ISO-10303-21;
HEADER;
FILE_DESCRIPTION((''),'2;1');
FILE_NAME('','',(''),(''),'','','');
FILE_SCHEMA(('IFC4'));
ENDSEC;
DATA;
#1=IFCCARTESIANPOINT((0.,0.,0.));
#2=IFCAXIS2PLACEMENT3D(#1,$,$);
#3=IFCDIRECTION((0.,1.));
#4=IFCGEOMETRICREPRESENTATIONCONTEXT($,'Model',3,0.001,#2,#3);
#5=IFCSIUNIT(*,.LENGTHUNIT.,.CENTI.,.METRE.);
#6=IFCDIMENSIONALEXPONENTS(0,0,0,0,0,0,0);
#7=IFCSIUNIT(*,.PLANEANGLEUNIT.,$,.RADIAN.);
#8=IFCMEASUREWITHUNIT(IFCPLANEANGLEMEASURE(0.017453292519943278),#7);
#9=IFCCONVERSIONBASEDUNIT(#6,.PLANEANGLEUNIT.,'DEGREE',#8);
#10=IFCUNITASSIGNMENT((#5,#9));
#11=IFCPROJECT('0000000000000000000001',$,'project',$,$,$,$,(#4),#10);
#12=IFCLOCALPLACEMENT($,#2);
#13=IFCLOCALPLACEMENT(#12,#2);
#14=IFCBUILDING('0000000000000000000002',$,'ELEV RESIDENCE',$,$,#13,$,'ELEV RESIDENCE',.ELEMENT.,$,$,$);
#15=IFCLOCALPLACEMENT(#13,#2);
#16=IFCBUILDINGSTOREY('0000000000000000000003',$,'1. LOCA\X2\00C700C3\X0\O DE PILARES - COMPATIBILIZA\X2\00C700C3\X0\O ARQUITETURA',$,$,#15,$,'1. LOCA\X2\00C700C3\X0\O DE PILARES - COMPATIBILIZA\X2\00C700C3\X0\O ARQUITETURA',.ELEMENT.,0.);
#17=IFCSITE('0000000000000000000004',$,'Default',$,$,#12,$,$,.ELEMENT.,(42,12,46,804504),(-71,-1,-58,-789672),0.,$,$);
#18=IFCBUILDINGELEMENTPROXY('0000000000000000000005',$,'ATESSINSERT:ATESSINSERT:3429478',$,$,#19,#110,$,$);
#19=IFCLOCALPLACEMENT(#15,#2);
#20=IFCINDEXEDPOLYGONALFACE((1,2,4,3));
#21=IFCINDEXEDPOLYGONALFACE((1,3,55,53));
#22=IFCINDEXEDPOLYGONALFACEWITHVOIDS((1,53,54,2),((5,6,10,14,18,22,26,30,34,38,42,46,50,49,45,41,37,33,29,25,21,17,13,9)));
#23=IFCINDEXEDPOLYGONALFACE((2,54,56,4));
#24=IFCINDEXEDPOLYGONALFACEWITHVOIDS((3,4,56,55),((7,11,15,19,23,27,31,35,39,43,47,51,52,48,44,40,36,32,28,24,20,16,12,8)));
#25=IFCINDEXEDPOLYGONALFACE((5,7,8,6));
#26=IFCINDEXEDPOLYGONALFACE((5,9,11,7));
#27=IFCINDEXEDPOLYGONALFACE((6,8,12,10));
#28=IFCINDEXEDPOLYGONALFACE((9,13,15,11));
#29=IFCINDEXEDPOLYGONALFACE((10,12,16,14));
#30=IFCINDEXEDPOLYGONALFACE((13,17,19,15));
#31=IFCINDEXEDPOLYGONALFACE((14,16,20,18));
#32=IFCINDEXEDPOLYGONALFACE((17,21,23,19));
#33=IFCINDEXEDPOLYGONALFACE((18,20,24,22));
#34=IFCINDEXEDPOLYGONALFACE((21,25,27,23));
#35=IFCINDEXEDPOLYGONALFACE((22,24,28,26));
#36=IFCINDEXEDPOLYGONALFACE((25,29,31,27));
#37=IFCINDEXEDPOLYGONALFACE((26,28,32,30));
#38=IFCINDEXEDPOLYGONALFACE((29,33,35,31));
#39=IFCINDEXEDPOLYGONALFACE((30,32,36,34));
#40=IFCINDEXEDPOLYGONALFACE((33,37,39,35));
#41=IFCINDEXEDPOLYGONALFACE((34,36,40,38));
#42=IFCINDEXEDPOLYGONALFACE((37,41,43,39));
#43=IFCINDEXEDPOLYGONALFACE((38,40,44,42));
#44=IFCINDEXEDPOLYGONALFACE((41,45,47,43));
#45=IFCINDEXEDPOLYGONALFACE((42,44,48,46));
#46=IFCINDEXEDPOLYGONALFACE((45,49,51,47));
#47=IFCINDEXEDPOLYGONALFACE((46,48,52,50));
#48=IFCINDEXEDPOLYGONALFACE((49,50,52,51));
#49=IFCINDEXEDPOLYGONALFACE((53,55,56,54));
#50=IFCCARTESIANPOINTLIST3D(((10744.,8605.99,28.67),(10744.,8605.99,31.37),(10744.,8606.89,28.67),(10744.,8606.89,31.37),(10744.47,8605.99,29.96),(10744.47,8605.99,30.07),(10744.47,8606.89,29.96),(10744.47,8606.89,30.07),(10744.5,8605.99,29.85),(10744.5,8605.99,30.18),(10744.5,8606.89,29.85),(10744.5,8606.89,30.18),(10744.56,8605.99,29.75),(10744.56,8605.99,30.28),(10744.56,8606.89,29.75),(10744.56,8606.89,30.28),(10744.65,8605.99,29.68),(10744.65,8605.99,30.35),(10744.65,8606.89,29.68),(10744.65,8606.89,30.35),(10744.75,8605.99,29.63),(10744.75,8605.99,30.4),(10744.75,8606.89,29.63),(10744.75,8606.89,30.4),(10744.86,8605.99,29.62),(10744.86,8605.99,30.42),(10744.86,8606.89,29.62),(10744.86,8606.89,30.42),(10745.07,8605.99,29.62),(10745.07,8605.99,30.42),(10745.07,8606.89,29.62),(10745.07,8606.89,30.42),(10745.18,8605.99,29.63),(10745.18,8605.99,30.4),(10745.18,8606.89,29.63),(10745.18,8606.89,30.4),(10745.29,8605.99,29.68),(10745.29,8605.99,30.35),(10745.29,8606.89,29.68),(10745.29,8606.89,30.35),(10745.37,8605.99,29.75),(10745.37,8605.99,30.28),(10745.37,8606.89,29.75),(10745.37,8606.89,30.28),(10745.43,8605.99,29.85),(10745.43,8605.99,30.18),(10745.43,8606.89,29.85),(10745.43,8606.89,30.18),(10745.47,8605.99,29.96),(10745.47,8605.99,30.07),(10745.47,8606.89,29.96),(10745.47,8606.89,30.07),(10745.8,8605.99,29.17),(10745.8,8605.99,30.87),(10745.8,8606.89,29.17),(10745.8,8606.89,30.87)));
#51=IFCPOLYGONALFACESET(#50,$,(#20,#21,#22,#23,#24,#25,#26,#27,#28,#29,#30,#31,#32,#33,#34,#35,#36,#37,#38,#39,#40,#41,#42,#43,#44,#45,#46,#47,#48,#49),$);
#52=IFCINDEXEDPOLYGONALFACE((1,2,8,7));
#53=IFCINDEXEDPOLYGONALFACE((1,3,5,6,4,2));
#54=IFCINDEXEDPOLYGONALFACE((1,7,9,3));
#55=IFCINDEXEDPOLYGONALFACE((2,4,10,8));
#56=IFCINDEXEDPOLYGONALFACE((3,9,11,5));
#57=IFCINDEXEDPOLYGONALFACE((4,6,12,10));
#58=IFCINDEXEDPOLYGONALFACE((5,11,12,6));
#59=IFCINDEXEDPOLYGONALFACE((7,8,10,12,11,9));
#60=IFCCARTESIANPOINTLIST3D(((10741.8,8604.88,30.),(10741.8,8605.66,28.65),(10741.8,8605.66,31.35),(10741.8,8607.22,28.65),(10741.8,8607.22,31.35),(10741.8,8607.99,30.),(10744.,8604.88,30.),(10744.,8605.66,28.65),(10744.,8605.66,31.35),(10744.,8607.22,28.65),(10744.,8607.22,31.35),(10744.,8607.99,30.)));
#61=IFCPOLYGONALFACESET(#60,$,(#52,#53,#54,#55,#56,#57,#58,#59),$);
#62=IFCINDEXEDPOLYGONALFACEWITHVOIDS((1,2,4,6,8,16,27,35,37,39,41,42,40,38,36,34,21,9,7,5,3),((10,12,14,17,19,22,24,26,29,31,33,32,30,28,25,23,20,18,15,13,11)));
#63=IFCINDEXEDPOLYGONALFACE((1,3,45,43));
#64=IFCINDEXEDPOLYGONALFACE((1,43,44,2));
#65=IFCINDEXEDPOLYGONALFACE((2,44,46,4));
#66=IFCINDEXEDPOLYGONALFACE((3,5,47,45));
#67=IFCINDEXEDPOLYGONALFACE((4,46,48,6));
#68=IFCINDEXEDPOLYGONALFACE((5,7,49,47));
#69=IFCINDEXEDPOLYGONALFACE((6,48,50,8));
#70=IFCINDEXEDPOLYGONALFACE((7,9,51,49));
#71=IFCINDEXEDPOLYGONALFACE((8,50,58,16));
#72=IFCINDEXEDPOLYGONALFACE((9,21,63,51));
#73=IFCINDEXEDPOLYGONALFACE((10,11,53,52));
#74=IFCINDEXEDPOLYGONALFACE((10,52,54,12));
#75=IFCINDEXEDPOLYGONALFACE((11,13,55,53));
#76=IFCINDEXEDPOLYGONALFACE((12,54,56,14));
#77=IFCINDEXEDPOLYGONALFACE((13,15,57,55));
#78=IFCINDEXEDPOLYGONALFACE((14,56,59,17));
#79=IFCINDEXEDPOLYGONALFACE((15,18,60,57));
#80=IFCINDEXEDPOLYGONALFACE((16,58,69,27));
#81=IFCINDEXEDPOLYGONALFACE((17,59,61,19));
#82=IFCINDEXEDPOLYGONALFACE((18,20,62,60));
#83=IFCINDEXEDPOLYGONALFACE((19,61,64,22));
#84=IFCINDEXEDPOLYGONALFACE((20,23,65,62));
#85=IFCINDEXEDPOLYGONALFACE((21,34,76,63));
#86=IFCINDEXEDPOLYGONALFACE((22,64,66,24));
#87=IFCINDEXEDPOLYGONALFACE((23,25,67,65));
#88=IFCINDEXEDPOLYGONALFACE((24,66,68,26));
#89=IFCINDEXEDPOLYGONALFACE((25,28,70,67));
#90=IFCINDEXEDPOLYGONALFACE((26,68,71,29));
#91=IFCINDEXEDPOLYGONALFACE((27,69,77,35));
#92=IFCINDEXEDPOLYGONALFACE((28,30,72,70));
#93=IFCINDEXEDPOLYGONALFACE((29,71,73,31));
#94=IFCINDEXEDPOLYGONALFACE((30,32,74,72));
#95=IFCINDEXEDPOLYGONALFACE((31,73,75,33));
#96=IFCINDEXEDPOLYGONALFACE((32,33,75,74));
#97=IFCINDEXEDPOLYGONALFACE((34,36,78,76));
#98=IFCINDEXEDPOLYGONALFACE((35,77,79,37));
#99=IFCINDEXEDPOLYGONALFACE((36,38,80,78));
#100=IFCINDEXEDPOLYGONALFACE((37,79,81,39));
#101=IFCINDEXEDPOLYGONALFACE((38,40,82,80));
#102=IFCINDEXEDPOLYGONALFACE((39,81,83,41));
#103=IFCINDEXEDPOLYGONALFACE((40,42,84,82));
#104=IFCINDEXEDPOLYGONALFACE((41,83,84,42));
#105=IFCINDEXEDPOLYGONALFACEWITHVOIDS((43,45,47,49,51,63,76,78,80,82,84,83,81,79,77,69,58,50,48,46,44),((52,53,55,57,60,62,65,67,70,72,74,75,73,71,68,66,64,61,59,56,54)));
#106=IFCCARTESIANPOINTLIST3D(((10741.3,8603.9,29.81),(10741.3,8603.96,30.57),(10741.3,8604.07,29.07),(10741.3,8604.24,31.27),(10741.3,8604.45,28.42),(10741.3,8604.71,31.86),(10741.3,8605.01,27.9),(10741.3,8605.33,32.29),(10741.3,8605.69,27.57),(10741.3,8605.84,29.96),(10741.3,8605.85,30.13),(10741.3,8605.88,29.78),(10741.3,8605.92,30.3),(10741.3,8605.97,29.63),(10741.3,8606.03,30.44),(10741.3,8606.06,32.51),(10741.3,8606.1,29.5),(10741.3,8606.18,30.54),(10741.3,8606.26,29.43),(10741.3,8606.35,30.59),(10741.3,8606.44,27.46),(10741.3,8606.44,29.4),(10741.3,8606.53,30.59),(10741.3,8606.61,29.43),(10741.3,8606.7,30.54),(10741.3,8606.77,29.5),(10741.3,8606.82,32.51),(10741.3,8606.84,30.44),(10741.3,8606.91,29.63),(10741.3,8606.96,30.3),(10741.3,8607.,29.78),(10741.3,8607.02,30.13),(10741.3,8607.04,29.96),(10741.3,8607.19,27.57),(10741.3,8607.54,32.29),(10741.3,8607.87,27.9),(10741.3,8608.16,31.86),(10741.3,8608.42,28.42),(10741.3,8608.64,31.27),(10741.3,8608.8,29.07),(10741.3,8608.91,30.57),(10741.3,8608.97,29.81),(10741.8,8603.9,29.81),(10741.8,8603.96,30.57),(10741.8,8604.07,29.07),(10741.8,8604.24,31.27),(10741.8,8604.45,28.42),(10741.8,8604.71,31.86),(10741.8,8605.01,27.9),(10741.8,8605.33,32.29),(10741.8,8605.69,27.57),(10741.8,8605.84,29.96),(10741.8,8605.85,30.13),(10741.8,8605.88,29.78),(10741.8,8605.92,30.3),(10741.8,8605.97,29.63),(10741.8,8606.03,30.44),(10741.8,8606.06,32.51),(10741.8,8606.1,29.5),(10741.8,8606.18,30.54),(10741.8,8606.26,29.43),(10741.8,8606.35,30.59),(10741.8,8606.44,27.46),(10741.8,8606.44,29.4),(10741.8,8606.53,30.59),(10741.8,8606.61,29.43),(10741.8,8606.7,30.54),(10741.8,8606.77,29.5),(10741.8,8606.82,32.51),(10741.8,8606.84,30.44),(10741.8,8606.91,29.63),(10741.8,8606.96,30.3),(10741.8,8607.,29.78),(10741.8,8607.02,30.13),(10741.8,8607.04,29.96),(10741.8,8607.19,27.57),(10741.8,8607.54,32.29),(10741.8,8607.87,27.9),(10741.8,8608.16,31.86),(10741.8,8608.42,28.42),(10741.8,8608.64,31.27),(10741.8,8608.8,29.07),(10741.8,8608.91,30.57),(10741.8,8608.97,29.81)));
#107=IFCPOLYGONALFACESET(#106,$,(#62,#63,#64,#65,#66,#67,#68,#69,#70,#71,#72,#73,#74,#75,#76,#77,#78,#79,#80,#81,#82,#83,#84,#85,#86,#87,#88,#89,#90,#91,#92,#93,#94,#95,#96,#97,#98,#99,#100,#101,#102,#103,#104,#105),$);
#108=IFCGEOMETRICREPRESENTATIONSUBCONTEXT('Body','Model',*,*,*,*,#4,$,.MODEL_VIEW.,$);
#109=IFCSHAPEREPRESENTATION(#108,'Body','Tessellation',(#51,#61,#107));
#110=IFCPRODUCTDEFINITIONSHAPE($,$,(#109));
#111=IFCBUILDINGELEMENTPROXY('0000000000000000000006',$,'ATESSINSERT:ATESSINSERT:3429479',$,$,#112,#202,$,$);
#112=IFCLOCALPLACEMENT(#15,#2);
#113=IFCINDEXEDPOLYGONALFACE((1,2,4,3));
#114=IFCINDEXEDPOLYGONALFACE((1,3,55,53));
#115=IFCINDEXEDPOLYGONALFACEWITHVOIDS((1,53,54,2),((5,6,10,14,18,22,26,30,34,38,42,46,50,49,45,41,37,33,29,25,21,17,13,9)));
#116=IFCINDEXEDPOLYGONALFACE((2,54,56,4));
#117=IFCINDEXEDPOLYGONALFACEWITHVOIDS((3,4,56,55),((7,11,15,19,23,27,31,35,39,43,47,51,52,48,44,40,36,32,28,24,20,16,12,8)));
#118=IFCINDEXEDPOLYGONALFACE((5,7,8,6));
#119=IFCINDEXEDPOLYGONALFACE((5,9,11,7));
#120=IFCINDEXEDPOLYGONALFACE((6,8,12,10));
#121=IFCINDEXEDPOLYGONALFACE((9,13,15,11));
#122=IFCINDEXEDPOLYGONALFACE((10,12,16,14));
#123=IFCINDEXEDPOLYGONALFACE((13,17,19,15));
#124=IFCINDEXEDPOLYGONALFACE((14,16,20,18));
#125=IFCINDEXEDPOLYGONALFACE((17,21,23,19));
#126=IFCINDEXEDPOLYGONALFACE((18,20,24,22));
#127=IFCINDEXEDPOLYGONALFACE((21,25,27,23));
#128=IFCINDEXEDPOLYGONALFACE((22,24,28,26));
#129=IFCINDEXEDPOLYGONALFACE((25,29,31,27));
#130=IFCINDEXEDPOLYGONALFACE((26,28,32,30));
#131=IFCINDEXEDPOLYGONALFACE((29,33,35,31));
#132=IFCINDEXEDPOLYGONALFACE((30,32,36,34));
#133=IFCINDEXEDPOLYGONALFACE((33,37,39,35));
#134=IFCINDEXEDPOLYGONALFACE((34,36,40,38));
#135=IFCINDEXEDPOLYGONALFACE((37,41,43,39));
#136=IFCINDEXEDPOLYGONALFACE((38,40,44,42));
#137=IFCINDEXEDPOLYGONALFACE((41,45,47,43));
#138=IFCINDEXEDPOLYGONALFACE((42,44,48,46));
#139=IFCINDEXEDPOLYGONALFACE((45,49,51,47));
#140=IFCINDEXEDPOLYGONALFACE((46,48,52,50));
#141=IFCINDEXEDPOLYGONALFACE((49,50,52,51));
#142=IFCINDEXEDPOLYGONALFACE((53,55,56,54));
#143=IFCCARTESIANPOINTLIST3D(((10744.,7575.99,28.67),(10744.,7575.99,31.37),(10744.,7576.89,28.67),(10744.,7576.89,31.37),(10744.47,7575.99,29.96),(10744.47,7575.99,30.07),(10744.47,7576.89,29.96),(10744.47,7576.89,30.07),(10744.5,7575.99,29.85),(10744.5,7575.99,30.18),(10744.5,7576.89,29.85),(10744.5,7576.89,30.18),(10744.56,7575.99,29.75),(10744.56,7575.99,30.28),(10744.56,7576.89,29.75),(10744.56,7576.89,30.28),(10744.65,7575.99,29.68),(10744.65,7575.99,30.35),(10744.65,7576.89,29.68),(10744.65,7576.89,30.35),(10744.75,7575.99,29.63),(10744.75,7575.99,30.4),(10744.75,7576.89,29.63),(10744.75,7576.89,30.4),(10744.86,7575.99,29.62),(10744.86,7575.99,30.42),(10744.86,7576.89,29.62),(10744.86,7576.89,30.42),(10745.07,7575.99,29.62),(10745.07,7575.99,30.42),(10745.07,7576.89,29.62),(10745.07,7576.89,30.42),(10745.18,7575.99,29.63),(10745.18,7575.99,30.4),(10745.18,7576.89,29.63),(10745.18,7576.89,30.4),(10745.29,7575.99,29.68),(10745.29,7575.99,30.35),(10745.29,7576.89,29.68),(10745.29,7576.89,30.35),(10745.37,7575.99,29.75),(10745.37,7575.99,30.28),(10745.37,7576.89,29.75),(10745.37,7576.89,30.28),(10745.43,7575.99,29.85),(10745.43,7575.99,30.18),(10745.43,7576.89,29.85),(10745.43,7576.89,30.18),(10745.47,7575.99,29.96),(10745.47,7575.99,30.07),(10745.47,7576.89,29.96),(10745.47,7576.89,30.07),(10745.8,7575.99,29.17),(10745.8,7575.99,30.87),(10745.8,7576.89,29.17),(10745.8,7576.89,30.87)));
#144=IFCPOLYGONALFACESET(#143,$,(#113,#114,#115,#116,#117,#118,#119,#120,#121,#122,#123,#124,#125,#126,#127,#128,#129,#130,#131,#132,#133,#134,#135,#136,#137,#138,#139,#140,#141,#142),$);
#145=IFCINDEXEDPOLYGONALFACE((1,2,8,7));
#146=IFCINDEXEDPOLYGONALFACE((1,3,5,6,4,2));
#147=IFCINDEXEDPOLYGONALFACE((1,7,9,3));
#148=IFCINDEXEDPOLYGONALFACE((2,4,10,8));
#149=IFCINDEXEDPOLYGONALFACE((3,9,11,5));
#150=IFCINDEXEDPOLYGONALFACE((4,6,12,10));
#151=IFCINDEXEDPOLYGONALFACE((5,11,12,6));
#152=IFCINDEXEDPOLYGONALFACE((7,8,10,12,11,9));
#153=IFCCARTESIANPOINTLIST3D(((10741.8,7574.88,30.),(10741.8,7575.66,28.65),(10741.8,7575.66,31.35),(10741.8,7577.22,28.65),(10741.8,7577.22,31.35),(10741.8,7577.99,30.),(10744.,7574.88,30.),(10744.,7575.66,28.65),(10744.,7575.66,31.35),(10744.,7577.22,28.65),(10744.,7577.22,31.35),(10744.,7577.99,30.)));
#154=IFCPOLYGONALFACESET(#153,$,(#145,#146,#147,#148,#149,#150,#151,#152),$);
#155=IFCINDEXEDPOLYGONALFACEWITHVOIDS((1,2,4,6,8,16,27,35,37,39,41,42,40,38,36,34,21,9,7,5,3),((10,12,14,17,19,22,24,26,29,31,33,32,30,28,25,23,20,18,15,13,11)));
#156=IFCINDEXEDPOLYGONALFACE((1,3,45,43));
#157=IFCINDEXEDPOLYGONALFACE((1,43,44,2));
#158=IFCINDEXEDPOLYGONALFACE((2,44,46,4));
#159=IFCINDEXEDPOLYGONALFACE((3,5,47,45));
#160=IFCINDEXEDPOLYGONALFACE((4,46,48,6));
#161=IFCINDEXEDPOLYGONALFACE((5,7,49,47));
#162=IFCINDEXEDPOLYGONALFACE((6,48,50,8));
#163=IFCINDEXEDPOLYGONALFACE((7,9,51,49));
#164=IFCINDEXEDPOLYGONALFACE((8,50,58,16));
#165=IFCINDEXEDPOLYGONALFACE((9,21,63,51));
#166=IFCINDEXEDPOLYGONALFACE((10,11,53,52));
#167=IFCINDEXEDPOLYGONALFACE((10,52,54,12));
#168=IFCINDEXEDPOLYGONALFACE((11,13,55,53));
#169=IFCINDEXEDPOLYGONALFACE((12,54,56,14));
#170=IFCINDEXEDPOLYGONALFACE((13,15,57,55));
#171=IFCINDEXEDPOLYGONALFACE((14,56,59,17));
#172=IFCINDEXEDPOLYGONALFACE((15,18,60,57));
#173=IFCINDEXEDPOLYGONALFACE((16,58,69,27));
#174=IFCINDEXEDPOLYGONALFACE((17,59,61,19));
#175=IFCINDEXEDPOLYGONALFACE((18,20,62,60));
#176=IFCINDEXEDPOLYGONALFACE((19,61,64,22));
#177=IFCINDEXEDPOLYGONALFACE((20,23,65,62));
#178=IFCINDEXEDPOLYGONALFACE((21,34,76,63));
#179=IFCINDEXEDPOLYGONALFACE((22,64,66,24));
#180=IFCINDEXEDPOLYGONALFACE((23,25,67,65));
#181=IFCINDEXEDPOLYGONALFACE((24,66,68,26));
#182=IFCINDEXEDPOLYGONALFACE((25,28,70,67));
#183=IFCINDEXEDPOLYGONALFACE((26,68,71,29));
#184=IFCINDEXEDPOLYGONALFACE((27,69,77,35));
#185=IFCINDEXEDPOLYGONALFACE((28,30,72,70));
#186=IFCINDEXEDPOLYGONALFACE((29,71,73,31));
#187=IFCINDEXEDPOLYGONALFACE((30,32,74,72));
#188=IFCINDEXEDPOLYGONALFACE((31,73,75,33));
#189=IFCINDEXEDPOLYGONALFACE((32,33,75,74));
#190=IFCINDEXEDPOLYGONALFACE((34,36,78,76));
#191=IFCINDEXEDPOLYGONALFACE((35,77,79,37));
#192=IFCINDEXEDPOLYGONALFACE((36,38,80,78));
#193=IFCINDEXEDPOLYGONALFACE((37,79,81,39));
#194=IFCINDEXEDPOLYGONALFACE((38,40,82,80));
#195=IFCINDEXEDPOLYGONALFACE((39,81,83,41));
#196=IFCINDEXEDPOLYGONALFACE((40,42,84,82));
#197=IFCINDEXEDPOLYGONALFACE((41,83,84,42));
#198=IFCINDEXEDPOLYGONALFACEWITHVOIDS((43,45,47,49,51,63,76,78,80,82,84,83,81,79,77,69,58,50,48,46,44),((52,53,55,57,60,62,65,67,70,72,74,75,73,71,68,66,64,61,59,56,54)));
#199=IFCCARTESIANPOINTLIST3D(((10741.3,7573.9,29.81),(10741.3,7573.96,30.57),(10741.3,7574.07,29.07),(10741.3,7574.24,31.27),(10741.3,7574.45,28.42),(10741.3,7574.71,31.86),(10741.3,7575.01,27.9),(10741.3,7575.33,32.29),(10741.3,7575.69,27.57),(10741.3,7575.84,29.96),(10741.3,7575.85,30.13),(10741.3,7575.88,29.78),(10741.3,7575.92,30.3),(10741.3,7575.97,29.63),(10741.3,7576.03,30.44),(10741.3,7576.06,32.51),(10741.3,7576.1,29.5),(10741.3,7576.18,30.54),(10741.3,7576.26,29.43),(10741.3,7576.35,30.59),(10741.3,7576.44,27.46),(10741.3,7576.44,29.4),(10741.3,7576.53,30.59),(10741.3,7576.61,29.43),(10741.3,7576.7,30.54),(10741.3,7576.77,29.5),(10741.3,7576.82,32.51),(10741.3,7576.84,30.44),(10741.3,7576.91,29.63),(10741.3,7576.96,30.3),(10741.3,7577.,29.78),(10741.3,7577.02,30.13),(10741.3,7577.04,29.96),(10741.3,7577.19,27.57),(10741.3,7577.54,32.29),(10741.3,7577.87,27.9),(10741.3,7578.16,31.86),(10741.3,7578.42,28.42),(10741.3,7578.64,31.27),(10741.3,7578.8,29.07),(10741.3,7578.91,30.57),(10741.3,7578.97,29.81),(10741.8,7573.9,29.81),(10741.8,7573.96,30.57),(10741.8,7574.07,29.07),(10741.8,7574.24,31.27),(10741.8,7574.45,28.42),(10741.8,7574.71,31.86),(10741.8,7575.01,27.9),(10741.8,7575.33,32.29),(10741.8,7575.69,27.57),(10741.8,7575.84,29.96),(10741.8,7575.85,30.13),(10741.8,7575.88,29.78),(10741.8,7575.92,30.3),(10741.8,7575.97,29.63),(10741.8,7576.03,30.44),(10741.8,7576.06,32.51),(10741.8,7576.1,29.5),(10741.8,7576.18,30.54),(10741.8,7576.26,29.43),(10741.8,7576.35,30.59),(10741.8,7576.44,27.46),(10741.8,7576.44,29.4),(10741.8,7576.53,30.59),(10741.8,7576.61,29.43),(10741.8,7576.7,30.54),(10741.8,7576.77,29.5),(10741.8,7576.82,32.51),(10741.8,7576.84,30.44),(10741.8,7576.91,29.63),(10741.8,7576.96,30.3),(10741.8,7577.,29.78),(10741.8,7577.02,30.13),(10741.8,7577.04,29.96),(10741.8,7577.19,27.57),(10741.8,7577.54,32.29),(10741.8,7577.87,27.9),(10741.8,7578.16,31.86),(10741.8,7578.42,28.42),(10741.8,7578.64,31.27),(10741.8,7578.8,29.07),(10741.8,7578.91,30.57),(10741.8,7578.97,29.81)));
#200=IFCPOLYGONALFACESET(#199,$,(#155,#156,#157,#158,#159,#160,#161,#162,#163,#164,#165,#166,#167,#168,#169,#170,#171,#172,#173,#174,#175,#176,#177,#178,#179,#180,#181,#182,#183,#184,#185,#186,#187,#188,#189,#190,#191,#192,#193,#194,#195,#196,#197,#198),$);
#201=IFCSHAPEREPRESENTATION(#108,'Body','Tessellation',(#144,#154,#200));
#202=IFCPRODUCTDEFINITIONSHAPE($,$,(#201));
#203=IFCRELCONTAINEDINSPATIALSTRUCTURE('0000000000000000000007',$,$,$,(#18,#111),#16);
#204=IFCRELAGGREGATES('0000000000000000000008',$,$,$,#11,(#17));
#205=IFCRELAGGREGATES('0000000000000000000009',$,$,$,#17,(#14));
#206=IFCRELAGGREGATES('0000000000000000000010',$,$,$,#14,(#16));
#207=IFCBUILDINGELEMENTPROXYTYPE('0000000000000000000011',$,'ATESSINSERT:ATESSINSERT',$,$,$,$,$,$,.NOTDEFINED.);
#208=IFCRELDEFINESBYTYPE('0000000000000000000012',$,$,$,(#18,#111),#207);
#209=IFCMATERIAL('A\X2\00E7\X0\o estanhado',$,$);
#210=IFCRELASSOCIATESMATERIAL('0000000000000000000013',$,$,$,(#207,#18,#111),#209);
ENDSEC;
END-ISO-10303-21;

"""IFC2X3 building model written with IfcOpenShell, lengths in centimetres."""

from ifc_helpers import new_model, entity, si_unit, converted_unit, direction, frame, frame_2d, origin, place, context, subcontext, project, spatial, polyline, circle_curve, parameter, trimmed, segment, composite_curve, hollow_circle, outline, extrude, source, transform, mapped, material, type_object, type_shapes, element, save


model = new_model("IFC2X3")

# Units and contexts
model_context = context("Model", 3, precision=0.001, world=origin(), true_north=direction((0.0, 1.0)))
body_context = subcontext(model_context, "Body", "Model", "MODEL_VIEW")
ifc_project = project(units=[si_unit("LENGTHUNIT", "METRE", prefix="CENTI"), converted_unit("PLANEANGLEUNIT", "DEGREE", entity("IfcPlaneAngleMeasure", 0.017453292519943278), si_unit("PLANEANGLEUNIT", "RADIAN"), dimensions=[0, 0, 0, 0, 0, 0, 0])], contexts=[model_context])

# Site, building, storey
site_placement = place(None, origin())
site = spatial("IfcSite", under=ifc_project, at=site_placement, Name="Default", CompositionType="ELEMENT", RefLatitude=(42, 12, 46, 804504), RefLongitude=(-71, -1, -58, -789672), RefElevation=0.0)
building_placement = place(site_placement, origin())
building = spatial("IfcBuilding", under=site, at=building_placement, Name="ELEV RESIDENCE", LongName="ELEV RESIDENCE", CompositionType="ELEMENT")
storey_placement = place(building_placement, origin())
storey = spatial("IfcBuildingStorey", under=building, at=storey_placement, Name="1. LOCAÇÃO DE PILARES - COMPATIBILIZAÇÃO ARQUITETURA", LongName="1. LOCAÇÃO DE PILARES - COMPATIBILIZAÇÃO ARQUITETURA", CompositionType="ELEMENT", Elevation=0.0)

# Building element proxies
ifc_material_1 = material(Name="Aço estanhado")
building_element_proxy_type_1 = type_object("IfcBuildingElementProxyType", Name="ATESSINSERT:ATESSINSERT", PredefinedType="NOTDEFINED", material=ifc_material_1)
shared_shape_1 = source(origin(), body_context, "Body", "SweptSolid", [
    extrude(outline(polyline([(-1.35, -0.9), (1.35, -0.9), (0.85, 0.9), (-0.85, 0.9), (-1.35, -0.9)]), holes=[composite_curve([segment(trimmed(circle_curve(frame_2d((0.0, 0.17), x_axis=(1.0, 0.0)), 0.4), [parameter(0.0)], [parameter(180.0)], True, "PARAMETER"), False, "CONTINUOUS"), segment(polyline([(0.4, 0.17), (0.4, -0.03)]), True, "CONTINUOUS"), segment(trimmed(circle_curve(frame_2d((0.0, -0.03), x_axis=(1.0, 0.0)), 0.4), [parameter(180.0)], [parameter(0.0)], True, "PARAMETER"), False, "CONTINUOUS"), segment(polyline([(-0.4, -0.03), (-0.4, 0.17)]), True, "CONTINUOUS")], self_intersect=False)]), frame((-1.4, -0.45, 30.02), z_axis=(0.0, 1.0, 0.0), x_axis=(0.0, 0.0, 1.0)), (0.0, 0.0, 1.0), 0.9),
    extrude(outline(polyline([(-0.78, -1.35), (0.78, -1.35), (1.56, 0.0), (0.78, 1.35), (-0.78, 1.35), (-1.56, 0.0), (-0.78, -1.35)])), frame((-4.5, 0.0, 30.0), z_axis=(1.0, 0.0, 0.0), x_axis=(0.0, 1.0, 0.0)), (0.0, 0.0, 1.0), 2.2),
    extrude(hollow_circle(Radius=2.54, WallThickness=1.94, at=frame_2d((0.0, 0.0), x_axis=(1.0, 0.0))), frame((-5.0, 0.0, 30.0), z_axis=(1.0, 0.0, 0.0), x_axis=(0.0, 0.0, -1.0)), (0.0, 0.0, 1.0), 0.5),
])
type_shapes(building_element_proxy_type_1, [shared_shape_1])
for number, where, name in (
    (1, (10746.3, 8606.44, 0.0), "ATESSINSERT:ATESSINSERT:3429478"),
    (2, (10746.3, 7576.44, 0.0), "ATESSINSERT:ATESSINSERT:3429479"),
):
    element("IfcBuildingElementProxy", number, at=place(storey_placement, frame(where)), inside=storey, type_object=building_element_proxy_type_1, material=ifc_material_1, Name=name, context=body_context, shape_type="MappedRepresentation", body=[
        mapped(shared_shape_1, transform((0.0, 0.0, 0.0), scale=1.0)),
    ])

save(model, "model.ifc")
